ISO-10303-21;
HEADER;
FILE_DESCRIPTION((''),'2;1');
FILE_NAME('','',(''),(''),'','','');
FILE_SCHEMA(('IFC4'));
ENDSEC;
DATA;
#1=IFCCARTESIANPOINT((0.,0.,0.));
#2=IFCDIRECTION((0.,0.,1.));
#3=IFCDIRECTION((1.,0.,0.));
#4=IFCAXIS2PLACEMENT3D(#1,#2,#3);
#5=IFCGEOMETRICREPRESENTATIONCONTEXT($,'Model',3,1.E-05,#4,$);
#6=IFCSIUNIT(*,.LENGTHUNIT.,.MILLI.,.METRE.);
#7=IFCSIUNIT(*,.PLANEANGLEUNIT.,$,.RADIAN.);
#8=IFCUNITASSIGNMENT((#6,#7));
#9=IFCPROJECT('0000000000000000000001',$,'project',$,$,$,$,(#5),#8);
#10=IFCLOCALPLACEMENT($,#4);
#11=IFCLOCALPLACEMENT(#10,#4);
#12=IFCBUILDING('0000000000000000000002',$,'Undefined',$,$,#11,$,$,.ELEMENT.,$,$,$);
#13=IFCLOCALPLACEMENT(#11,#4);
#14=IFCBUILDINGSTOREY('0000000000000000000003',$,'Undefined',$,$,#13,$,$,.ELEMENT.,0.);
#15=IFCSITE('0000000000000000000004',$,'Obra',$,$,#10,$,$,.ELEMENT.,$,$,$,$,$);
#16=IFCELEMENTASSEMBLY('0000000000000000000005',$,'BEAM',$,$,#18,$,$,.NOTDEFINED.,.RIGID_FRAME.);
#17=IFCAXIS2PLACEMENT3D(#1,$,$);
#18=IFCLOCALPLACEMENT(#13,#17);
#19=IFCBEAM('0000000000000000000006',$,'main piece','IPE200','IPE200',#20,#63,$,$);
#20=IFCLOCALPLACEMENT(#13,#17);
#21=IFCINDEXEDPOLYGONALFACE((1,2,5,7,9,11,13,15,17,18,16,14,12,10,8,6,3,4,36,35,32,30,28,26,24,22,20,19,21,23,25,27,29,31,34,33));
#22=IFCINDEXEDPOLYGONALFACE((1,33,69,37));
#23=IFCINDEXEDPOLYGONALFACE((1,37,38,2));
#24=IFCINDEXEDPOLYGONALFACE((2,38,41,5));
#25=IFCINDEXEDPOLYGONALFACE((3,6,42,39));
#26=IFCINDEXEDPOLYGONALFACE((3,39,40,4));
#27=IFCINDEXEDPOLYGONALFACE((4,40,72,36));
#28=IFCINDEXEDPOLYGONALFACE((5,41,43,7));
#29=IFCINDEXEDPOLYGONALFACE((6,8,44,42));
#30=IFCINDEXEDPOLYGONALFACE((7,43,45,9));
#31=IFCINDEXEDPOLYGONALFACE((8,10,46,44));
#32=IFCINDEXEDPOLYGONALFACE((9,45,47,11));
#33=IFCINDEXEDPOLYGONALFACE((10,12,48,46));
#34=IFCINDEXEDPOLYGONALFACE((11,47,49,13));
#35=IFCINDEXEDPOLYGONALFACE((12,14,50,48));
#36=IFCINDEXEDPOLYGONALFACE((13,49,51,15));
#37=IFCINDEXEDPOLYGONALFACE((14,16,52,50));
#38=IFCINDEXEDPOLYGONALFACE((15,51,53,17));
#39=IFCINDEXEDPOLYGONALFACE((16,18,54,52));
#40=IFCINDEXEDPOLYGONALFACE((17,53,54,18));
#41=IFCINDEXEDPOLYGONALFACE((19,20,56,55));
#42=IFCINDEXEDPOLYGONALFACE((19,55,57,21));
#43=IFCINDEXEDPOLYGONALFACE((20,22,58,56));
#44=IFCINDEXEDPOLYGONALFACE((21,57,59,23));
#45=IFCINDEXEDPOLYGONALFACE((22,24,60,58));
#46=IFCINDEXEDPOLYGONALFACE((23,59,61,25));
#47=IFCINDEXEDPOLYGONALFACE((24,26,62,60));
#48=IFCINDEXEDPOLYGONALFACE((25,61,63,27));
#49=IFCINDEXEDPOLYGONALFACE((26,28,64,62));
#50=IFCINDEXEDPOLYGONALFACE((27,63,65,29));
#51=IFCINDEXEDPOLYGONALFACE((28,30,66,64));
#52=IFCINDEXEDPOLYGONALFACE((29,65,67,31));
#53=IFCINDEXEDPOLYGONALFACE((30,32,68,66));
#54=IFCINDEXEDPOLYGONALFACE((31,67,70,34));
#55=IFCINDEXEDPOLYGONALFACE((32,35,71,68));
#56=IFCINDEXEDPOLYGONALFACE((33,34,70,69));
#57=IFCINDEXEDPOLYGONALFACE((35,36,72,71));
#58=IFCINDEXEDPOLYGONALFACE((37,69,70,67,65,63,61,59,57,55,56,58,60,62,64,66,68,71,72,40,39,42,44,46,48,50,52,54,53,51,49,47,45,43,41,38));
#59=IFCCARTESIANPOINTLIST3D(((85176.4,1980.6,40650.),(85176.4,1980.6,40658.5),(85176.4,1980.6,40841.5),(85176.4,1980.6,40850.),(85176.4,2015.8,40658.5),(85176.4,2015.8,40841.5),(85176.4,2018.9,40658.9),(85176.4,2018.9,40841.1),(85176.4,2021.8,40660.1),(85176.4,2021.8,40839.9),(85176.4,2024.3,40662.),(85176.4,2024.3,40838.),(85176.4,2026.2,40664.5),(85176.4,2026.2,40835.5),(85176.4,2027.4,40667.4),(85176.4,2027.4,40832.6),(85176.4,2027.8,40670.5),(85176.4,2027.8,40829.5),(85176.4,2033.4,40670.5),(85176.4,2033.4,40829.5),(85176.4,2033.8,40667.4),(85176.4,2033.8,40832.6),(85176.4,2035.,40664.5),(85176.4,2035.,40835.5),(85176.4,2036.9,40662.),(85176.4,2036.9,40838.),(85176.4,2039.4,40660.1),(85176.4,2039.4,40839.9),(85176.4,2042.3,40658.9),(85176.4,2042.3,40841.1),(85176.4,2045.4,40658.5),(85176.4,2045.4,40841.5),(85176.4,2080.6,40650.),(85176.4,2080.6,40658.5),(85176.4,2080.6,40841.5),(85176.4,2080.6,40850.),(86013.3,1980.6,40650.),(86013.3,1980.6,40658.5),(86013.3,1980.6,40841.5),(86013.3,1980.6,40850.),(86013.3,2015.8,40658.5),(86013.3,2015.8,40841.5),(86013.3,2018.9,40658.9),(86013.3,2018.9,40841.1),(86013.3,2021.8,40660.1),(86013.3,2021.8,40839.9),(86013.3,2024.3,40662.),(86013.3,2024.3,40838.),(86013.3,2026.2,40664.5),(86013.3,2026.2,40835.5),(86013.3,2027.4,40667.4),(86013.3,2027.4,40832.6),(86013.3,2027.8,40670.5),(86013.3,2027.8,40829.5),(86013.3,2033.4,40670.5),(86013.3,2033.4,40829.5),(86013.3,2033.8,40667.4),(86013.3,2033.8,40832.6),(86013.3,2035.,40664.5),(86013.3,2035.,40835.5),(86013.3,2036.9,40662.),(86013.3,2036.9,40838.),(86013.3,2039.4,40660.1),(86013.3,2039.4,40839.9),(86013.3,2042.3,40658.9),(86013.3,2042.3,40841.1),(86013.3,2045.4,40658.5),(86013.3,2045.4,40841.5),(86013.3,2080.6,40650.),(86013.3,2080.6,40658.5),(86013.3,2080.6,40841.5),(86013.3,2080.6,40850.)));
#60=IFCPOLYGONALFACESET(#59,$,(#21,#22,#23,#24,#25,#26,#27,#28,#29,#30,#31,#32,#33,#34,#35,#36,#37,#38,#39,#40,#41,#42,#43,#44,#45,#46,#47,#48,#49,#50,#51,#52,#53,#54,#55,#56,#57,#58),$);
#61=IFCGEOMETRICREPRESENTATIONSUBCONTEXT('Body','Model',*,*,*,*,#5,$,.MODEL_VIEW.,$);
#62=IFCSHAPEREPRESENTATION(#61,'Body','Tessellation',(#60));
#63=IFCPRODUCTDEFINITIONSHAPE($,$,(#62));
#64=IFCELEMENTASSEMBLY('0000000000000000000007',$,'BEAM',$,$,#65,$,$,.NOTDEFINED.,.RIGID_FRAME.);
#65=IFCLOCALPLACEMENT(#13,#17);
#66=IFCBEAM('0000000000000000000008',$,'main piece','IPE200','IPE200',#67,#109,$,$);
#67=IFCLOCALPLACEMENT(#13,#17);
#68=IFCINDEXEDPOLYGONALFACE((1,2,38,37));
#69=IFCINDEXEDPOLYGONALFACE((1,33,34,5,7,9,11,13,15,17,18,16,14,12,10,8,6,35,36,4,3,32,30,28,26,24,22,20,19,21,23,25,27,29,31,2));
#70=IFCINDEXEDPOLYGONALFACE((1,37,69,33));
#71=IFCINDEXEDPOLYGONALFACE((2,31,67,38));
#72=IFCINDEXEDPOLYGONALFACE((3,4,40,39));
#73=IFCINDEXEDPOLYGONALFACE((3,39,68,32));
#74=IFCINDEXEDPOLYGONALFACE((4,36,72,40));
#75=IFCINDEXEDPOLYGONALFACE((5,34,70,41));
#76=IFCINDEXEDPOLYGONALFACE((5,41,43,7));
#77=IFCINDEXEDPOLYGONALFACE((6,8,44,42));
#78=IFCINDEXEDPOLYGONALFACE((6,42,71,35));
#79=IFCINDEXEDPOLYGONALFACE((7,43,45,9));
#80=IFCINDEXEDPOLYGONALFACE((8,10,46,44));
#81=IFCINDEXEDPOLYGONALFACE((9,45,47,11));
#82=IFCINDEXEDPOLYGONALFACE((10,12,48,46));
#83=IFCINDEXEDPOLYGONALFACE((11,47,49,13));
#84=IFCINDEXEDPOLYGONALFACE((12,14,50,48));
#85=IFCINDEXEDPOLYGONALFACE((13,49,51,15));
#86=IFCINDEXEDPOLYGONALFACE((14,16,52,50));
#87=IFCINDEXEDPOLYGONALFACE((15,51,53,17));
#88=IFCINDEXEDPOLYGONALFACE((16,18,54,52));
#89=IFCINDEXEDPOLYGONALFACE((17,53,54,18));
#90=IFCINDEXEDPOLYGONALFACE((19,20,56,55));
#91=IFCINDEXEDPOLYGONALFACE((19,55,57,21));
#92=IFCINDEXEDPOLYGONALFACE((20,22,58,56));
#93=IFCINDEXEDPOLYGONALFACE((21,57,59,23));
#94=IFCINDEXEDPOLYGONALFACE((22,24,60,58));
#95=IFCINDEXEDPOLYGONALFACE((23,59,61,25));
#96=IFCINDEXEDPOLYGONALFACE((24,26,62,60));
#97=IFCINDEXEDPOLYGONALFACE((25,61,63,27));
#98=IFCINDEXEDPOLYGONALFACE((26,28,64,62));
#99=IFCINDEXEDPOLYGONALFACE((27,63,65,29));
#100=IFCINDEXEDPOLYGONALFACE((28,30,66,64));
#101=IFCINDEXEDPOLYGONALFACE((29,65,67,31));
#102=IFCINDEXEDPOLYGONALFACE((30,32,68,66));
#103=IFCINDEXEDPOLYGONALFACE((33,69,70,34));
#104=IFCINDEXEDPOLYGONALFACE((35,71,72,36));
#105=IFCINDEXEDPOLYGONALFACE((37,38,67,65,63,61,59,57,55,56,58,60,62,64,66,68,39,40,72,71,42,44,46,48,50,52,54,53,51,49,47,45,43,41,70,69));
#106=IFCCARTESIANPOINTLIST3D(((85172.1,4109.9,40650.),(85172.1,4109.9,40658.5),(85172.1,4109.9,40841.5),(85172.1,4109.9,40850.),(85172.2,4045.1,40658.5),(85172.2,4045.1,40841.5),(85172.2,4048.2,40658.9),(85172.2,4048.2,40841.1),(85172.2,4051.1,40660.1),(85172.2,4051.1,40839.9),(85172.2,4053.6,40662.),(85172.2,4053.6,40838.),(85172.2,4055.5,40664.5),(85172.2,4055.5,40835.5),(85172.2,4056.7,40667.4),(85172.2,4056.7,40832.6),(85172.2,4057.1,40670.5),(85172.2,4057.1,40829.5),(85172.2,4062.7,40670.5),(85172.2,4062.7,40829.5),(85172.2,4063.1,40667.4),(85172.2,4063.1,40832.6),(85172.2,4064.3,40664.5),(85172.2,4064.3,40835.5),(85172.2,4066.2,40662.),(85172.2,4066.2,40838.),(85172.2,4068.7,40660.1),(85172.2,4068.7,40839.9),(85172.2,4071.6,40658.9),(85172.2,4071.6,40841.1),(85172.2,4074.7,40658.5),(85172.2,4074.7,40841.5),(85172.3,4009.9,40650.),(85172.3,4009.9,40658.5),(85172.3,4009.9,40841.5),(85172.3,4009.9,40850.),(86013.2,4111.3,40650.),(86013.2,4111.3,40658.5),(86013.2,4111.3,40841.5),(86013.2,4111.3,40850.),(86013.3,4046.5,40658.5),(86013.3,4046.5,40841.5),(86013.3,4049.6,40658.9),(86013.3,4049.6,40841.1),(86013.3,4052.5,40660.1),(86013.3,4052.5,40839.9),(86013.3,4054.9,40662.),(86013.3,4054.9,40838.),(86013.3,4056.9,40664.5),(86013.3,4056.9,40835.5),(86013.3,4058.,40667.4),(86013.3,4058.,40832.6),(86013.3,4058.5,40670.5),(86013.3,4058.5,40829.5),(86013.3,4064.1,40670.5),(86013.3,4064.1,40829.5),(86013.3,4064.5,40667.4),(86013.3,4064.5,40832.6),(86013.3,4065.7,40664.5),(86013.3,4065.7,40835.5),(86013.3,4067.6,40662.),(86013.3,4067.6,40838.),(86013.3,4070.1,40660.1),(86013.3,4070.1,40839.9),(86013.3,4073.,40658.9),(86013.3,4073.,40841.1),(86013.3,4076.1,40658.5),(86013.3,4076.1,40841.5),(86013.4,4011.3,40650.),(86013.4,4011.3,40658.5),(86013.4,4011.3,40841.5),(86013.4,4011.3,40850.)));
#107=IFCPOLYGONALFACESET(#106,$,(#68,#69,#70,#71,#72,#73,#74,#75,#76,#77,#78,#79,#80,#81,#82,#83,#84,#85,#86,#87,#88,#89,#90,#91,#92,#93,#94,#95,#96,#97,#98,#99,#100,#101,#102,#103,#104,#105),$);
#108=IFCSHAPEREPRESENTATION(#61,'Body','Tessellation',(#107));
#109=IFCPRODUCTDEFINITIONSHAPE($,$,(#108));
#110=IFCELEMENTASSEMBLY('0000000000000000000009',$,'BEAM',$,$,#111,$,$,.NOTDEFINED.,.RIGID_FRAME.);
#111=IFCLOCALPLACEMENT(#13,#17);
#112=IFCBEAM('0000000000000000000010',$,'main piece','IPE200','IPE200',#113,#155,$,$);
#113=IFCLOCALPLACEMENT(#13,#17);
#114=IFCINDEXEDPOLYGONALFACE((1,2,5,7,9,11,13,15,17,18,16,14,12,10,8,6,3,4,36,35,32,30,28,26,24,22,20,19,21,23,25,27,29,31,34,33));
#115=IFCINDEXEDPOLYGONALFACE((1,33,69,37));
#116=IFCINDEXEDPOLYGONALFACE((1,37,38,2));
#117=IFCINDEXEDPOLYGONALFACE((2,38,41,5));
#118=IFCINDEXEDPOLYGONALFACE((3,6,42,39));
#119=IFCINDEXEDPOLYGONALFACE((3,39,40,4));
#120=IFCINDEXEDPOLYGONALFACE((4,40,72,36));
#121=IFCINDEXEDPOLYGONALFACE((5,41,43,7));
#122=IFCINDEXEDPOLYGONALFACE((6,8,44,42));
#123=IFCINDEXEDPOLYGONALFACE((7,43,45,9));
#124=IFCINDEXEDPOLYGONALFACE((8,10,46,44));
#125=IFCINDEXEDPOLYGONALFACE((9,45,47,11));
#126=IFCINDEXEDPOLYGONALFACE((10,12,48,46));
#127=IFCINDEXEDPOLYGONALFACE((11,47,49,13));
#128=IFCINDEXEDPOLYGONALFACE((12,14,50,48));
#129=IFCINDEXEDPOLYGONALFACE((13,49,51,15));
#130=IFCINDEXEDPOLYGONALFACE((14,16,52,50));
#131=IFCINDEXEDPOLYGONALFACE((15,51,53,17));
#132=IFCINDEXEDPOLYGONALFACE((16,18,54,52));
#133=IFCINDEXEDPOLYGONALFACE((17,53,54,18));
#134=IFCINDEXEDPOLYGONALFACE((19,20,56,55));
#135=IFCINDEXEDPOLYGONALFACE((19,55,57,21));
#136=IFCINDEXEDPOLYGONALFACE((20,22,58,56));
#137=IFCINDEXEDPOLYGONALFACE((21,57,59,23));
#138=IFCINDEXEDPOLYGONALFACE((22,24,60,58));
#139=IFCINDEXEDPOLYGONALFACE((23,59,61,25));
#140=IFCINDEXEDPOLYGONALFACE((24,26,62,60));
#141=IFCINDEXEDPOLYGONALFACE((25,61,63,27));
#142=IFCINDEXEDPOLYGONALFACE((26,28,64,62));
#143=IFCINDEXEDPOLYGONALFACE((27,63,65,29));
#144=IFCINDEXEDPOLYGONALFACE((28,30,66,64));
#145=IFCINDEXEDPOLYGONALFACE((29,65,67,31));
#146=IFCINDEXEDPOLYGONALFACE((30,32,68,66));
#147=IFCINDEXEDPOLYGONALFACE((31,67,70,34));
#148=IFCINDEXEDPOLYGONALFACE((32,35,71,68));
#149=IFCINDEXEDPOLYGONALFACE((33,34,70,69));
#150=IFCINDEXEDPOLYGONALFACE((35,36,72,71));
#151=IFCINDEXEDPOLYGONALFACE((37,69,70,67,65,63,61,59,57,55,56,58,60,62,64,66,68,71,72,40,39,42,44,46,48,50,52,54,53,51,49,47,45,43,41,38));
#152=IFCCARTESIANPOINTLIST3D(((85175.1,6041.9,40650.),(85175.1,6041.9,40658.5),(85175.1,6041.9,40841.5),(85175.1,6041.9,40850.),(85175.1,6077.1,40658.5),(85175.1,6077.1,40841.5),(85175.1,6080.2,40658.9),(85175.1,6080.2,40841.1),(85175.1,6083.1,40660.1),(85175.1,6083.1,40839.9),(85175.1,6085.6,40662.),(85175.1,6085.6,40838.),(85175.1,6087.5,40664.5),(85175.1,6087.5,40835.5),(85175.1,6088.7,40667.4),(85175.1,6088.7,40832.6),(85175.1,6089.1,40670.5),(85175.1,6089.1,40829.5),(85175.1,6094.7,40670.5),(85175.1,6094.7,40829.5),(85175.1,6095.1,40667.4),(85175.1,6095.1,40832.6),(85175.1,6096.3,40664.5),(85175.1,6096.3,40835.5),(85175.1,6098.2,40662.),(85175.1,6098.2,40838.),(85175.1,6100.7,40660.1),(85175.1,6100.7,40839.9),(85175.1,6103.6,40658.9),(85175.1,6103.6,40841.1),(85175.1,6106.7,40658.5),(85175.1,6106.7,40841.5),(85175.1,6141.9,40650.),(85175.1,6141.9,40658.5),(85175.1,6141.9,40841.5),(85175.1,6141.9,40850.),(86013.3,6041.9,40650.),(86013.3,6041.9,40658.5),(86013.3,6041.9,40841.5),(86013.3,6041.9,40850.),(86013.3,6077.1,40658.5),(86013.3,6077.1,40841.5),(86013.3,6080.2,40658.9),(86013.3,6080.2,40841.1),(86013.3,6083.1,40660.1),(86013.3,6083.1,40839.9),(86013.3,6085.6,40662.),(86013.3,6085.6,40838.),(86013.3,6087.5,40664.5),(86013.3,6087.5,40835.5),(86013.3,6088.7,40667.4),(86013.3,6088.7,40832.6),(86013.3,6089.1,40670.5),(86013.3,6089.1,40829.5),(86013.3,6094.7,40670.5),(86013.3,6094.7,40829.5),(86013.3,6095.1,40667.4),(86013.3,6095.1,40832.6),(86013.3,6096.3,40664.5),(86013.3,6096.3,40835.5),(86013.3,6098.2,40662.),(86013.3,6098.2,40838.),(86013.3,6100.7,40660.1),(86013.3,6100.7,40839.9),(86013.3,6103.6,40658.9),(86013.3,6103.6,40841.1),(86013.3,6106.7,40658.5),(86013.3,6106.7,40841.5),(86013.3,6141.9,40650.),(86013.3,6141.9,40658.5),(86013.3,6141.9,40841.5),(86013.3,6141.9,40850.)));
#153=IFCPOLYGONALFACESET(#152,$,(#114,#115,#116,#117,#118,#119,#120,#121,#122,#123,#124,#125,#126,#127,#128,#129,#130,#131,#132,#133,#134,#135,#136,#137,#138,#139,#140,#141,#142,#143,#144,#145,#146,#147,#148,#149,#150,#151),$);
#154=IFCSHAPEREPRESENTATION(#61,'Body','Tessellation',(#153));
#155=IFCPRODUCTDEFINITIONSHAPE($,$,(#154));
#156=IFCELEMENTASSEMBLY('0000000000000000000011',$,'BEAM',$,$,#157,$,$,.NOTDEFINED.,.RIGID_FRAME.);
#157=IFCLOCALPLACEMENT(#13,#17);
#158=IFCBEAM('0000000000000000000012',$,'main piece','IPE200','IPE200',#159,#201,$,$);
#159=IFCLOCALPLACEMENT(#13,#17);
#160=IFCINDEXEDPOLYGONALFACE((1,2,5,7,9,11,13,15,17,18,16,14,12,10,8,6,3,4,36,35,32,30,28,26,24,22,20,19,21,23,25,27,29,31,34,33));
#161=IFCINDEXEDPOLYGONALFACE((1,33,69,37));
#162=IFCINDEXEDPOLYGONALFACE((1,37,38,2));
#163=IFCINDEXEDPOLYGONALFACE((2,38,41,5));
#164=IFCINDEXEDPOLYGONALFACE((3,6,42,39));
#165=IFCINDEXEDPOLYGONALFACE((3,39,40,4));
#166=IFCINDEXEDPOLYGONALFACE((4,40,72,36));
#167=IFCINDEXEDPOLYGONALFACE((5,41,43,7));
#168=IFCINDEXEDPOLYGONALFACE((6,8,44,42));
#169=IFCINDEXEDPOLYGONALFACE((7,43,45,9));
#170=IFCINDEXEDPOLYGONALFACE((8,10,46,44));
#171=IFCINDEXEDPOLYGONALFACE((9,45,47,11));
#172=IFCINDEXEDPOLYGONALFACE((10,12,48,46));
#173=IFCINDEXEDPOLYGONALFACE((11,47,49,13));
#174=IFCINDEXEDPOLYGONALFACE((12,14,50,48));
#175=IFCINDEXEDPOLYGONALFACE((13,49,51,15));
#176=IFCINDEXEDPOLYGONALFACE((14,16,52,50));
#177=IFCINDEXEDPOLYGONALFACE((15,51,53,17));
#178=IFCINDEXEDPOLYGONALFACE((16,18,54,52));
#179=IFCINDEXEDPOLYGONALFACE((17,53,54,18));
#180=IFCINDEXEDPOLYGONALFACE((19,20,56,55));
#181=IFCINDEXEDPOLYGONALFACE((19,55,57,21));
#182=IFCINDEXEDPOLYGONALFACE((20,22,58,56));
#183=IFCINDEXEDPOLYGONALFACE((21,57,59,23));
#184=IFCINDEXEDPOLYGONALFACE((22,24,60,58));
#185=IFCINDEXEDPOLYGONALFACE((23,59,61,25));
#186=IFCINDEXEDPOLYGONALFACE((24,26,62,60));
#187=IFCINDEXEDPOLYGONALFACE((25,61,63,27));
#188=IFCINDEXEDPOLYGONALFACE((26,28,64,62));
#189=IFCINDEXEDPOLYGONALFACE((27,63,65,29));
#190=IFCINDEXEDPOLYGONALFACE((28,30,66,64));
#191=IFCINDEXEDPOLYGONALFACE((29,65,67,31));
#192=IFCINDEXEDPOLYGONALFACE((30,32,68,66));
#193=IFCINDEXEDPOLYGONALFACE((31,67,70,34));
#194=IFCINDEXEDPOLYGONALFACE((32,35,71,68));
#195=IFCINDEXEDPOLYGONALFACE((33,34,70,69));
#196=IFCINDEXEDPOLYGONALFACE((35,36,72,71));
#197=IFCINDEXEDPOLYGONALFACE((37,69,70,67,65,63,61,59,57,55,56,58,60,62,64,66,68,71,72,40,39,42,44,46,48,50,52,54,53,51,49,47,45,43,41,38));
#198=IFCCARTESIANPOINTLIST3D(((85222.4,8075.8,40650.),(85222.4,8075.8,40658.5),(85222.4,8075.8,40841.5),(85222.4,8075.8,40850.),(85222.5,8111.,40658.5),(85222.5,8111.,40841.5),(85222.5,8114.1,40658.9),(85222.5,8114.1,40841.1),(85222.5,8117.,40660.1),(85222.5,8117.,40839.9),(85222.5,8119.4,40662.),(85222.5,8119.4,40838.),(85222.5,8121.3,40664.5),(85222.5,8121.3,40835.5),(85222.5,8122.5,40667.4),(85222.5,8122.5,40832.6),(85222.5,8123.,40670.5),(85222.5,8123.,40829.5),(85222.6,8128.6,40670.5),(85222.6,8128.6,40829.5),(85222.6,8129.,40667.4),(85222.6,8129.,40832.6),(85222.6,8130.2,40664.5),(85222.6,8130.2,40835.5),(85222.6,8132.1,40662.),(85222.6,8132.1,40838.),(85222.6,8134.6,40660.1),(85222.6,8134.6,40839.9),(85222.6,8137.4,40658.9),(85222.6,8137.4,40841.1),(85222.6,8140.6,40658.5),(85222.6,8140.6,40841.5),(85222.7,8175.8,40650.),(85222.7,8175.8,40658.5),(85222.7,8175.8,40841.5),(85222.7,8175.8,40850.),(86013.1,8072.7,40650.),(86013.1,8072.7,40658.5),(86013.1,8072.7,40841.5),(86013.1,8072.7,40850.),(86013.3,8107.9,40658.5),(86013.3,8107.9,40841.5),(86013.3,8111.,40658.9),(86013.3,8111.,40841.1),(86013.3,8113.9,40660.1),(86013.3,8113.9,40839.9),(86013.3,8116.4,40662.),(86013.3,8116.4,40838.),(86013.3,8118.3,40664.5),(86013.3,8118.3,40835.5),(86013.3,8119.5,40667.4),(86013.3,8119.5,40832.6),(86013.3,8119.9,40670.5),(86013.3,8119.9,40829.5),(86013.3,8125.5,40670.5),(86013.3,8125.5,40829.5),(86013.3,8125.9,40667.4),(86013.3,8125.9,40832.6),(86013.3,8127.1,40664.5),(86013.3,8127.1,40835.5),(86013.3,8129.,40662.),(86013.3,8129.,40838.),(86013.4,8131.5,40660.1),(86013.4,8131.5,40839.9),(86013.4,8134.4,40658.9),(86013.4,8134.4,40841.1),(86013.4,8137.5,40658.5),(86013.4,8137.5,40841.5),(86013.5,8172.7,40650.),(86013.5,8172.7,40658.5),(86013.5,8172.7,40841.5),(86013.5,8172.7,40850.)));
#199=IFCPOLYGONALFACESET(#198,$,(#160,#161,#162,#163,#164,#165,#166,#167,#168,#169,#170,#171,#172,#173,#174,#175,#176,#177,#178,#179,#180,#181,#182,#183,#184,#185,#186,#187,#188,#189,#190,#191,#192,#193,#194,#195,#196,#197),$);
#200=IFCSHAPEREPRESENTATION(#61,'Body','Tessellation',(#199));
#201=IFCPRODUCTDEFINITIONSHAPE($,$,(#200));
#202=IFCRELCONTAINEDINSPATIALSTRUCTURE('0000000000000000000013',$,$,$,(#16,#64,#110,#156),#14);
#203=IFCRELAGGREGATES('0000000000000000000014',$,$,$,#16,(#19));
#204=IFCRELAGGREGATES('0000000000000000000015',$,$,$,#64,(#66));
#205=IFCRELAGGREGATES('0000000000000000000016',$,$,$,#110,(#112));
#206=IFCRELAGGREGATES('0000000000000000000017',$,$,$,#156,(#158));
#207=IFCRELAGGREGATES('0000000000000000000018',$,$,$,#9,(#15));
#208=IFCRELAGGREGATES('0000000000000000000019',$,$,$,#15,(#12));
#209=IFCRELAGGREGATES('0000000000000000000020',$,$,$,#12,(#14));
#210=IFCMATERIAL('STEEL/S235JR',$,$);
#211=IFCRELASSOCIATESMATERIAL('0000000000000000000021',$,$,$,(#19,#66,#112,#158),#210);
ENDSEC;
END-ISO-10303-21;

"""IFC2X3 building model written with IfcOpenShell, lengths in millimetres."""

from ifc_helpers import new_model, si_unit, frame, origin_with_axes, origin_2d_with_axis, place, context, subcontext, project, spatial, i_section, extrude, material, element, aggregate, save


model = new_model("IFC2X3")

# Units and contexts
model_context = context("Model", 3, precision=1e-05, world=origin_with_axes())
body_context = subcontext(model_context, "Body", "Model", "MODEL_VIEW")
ifc_project = project(units=[si_unit("LENGTHUNIT", "METRE", prefix="MILLI"), si_unit("PLANEANGLEUNIT", "RADIAN")], contexts=[model_context])

# Site, building, storey
site_placement = place(None, origin_with_axes())
site = spatial("IfcSite", under=ifc_project, at=site_placement, Name="Obra", CompositionType="ELEMENT")
building_placement = place(site_placement, origin_with_axes())
building = spatial("IfcBuilding", under=site, at=building_placement, Name="Undefined", CompositionType="ELEMENT")
storey_placement = place(building_placement, origin_with_axes())
storey = spatial("IfcBuildingStorey", under=building, at=storey_placement, Name="Undefined", CompositionType="ELEMENT", Elevation=0.0)

# Shared definitions
ifc_material_1 = material(Name="STEEL/S235JR")

# Element assemblies, beams
assembly_1_placement = place(storey_placement, origin_with_axes())
assembly_1 = element("IfcElementAssembly", 1, at=assembly_1_placement, inside=storey, Name="BEAM", AssemblyPlace="NOTDEFINED", PredefinedType="RIGID_FRAME")
beam_1_placement = place(assembly_1_placement, frame((85176.4, 2030.6, 40750.0), z_axis=(0.0, 0.0, 1.0), x_axis=(1.0, 0.0, 0.0)))
beam_1 = element("IfcBeam", 2, at=beam_1_placement, material=ifc_material_1, Name="main piece", Description="IPE200", ObjectType="IPE200", context=body_context, shape_type="SweptSolid", body=[
    extrude(i_section(OverallWidth=100.0, OverallDepth=200.0, WebThickness=5.6, FlangeThickness=8.5, FilletRadius=12.0, at=origin_2d_with_axis()), frame((836.9, 0.0, 0.0), z_axis=(-1.0, 0.0, 0.0), x_axis=(0.0, -1.0, 0.0)), (0.0, 0.0, 1.0), 836.9),
])
aggregate(assembly_1, [beam_1])
assembly_2_placement = place(storey_placement, origin_with_axes())
assembly_2 = element("IfcElementAssembly", 3, at=assembly_2_placement, inside=storey, Name="BEAM", AssemblyPlace="NOTDEFINED", PredefinedType="RIGID_FRAME")
beam_2_placement = place(assembly_2_placement, frame((85172.2, 4059.9, 40750.0), z_axis=(0.0, 0.0, 1.0), x_axis=(0.999999, 0.001616, 0.0)))
beam_2 = element("IfcBeam", 4, at=beam_2_placement, material=ifc_material_1, Name="main piece", Description="IPE200", ObjectType="IPE200", context=body_context, shape_type="SweptSolid", body=[
    extrude(i_section(OverallWidth=100.0, OverallDepth=200.0, WebThickness=5.6, FlangeThickness=8.5, FilletRadius=12.0, at=origin_2d_with_axis()), frame((841.1, 0.0, 0.0), z_axis=(-1.0, 0.0, 0.0), x_axis=(0.0, -1.0, 0.0)), (0.0, 0.0, 1.0), 841.1),
])
aggregate(assembly_2, [beam_2])
assembly_3_placement = place(storey_placement, origin_with_axes())
assembly_3 = element("IfcElementAssembly", 5, at=assembly_3_placement, inside=storey, Name="BEAM", AssemblyPlace="NOTDEFINED", PredefinedType="RIGID_FRAME")
beam_3_placement = place(assembly_3_placement, frame((85175.1, 6091.9, 40750.0), z_axis=(0.0, 0.0, 1.0), x_axis=(1.0, 0.0, 0.0)))
beam_3 = element("IfcBeam", 6, at=beam_3_placement, material=ifc_material_1, Name="main piece", Description="IPE200", ObjectType="IPE200", context=body_context, shape_type="SweptSolid", body=[
    extrude(i_section(OverallWidth=100.0, OverallDepth=200.0, WebThickness=5.6, FlangeThickness=8.5, FilletRadius=12.0, at=origin_2d_with_axis()), frame((838.2, 0.0, 0.0), z_axis=(-1.0, 0.0, 0.0), x_axis=(0.0, -1.0, 0.0)), (0.0, 0.0, 1.0), 838.2),
])
aggregate(assembly_3, [beam_3])
assembly_4_placement = place(storey_placement, origin_with_axes())
assembly_4 = element("IfcElementAssembly", 7, at=assembly_4_placement, inside=storey, Name="BEAM", AssemblyPlace="NOTDEFINED", PredefinedType="RIGID_FRAME")
beam_4_placement = place(assembly_4_placement, frame((85222.6, 8125.8, 40750.0), z_axis=(0.0, 0.0, 1.0), x_axis=(0.999993, -0.003858, 0.0)))
beam_4 = element("IfcBeam", 8, at=beam_4_placement, material=ifc_material_1, Name="main piece", Description="IPE200", ObjectType="IPE200", context=body_context, shape_type="SweptSolid", body=[
    extrude(i_section(OverallWidth=100.0, OverallDepth=200.0, WebThickness=5.6, FlangeThickness=8.5, FilletRadius=12.0, at=origin_2d_with_axis()), frame((790.8, 0.0, 0.0), z_axis=(-1.0, 0.0, 0.0), x_axis=(0.0, -1.0, 0.0)), (0.0, 0.0, 1.0), 790.8),
])
aggregate(assembly_4, [beam_4])

save(model, "model.ifc")
